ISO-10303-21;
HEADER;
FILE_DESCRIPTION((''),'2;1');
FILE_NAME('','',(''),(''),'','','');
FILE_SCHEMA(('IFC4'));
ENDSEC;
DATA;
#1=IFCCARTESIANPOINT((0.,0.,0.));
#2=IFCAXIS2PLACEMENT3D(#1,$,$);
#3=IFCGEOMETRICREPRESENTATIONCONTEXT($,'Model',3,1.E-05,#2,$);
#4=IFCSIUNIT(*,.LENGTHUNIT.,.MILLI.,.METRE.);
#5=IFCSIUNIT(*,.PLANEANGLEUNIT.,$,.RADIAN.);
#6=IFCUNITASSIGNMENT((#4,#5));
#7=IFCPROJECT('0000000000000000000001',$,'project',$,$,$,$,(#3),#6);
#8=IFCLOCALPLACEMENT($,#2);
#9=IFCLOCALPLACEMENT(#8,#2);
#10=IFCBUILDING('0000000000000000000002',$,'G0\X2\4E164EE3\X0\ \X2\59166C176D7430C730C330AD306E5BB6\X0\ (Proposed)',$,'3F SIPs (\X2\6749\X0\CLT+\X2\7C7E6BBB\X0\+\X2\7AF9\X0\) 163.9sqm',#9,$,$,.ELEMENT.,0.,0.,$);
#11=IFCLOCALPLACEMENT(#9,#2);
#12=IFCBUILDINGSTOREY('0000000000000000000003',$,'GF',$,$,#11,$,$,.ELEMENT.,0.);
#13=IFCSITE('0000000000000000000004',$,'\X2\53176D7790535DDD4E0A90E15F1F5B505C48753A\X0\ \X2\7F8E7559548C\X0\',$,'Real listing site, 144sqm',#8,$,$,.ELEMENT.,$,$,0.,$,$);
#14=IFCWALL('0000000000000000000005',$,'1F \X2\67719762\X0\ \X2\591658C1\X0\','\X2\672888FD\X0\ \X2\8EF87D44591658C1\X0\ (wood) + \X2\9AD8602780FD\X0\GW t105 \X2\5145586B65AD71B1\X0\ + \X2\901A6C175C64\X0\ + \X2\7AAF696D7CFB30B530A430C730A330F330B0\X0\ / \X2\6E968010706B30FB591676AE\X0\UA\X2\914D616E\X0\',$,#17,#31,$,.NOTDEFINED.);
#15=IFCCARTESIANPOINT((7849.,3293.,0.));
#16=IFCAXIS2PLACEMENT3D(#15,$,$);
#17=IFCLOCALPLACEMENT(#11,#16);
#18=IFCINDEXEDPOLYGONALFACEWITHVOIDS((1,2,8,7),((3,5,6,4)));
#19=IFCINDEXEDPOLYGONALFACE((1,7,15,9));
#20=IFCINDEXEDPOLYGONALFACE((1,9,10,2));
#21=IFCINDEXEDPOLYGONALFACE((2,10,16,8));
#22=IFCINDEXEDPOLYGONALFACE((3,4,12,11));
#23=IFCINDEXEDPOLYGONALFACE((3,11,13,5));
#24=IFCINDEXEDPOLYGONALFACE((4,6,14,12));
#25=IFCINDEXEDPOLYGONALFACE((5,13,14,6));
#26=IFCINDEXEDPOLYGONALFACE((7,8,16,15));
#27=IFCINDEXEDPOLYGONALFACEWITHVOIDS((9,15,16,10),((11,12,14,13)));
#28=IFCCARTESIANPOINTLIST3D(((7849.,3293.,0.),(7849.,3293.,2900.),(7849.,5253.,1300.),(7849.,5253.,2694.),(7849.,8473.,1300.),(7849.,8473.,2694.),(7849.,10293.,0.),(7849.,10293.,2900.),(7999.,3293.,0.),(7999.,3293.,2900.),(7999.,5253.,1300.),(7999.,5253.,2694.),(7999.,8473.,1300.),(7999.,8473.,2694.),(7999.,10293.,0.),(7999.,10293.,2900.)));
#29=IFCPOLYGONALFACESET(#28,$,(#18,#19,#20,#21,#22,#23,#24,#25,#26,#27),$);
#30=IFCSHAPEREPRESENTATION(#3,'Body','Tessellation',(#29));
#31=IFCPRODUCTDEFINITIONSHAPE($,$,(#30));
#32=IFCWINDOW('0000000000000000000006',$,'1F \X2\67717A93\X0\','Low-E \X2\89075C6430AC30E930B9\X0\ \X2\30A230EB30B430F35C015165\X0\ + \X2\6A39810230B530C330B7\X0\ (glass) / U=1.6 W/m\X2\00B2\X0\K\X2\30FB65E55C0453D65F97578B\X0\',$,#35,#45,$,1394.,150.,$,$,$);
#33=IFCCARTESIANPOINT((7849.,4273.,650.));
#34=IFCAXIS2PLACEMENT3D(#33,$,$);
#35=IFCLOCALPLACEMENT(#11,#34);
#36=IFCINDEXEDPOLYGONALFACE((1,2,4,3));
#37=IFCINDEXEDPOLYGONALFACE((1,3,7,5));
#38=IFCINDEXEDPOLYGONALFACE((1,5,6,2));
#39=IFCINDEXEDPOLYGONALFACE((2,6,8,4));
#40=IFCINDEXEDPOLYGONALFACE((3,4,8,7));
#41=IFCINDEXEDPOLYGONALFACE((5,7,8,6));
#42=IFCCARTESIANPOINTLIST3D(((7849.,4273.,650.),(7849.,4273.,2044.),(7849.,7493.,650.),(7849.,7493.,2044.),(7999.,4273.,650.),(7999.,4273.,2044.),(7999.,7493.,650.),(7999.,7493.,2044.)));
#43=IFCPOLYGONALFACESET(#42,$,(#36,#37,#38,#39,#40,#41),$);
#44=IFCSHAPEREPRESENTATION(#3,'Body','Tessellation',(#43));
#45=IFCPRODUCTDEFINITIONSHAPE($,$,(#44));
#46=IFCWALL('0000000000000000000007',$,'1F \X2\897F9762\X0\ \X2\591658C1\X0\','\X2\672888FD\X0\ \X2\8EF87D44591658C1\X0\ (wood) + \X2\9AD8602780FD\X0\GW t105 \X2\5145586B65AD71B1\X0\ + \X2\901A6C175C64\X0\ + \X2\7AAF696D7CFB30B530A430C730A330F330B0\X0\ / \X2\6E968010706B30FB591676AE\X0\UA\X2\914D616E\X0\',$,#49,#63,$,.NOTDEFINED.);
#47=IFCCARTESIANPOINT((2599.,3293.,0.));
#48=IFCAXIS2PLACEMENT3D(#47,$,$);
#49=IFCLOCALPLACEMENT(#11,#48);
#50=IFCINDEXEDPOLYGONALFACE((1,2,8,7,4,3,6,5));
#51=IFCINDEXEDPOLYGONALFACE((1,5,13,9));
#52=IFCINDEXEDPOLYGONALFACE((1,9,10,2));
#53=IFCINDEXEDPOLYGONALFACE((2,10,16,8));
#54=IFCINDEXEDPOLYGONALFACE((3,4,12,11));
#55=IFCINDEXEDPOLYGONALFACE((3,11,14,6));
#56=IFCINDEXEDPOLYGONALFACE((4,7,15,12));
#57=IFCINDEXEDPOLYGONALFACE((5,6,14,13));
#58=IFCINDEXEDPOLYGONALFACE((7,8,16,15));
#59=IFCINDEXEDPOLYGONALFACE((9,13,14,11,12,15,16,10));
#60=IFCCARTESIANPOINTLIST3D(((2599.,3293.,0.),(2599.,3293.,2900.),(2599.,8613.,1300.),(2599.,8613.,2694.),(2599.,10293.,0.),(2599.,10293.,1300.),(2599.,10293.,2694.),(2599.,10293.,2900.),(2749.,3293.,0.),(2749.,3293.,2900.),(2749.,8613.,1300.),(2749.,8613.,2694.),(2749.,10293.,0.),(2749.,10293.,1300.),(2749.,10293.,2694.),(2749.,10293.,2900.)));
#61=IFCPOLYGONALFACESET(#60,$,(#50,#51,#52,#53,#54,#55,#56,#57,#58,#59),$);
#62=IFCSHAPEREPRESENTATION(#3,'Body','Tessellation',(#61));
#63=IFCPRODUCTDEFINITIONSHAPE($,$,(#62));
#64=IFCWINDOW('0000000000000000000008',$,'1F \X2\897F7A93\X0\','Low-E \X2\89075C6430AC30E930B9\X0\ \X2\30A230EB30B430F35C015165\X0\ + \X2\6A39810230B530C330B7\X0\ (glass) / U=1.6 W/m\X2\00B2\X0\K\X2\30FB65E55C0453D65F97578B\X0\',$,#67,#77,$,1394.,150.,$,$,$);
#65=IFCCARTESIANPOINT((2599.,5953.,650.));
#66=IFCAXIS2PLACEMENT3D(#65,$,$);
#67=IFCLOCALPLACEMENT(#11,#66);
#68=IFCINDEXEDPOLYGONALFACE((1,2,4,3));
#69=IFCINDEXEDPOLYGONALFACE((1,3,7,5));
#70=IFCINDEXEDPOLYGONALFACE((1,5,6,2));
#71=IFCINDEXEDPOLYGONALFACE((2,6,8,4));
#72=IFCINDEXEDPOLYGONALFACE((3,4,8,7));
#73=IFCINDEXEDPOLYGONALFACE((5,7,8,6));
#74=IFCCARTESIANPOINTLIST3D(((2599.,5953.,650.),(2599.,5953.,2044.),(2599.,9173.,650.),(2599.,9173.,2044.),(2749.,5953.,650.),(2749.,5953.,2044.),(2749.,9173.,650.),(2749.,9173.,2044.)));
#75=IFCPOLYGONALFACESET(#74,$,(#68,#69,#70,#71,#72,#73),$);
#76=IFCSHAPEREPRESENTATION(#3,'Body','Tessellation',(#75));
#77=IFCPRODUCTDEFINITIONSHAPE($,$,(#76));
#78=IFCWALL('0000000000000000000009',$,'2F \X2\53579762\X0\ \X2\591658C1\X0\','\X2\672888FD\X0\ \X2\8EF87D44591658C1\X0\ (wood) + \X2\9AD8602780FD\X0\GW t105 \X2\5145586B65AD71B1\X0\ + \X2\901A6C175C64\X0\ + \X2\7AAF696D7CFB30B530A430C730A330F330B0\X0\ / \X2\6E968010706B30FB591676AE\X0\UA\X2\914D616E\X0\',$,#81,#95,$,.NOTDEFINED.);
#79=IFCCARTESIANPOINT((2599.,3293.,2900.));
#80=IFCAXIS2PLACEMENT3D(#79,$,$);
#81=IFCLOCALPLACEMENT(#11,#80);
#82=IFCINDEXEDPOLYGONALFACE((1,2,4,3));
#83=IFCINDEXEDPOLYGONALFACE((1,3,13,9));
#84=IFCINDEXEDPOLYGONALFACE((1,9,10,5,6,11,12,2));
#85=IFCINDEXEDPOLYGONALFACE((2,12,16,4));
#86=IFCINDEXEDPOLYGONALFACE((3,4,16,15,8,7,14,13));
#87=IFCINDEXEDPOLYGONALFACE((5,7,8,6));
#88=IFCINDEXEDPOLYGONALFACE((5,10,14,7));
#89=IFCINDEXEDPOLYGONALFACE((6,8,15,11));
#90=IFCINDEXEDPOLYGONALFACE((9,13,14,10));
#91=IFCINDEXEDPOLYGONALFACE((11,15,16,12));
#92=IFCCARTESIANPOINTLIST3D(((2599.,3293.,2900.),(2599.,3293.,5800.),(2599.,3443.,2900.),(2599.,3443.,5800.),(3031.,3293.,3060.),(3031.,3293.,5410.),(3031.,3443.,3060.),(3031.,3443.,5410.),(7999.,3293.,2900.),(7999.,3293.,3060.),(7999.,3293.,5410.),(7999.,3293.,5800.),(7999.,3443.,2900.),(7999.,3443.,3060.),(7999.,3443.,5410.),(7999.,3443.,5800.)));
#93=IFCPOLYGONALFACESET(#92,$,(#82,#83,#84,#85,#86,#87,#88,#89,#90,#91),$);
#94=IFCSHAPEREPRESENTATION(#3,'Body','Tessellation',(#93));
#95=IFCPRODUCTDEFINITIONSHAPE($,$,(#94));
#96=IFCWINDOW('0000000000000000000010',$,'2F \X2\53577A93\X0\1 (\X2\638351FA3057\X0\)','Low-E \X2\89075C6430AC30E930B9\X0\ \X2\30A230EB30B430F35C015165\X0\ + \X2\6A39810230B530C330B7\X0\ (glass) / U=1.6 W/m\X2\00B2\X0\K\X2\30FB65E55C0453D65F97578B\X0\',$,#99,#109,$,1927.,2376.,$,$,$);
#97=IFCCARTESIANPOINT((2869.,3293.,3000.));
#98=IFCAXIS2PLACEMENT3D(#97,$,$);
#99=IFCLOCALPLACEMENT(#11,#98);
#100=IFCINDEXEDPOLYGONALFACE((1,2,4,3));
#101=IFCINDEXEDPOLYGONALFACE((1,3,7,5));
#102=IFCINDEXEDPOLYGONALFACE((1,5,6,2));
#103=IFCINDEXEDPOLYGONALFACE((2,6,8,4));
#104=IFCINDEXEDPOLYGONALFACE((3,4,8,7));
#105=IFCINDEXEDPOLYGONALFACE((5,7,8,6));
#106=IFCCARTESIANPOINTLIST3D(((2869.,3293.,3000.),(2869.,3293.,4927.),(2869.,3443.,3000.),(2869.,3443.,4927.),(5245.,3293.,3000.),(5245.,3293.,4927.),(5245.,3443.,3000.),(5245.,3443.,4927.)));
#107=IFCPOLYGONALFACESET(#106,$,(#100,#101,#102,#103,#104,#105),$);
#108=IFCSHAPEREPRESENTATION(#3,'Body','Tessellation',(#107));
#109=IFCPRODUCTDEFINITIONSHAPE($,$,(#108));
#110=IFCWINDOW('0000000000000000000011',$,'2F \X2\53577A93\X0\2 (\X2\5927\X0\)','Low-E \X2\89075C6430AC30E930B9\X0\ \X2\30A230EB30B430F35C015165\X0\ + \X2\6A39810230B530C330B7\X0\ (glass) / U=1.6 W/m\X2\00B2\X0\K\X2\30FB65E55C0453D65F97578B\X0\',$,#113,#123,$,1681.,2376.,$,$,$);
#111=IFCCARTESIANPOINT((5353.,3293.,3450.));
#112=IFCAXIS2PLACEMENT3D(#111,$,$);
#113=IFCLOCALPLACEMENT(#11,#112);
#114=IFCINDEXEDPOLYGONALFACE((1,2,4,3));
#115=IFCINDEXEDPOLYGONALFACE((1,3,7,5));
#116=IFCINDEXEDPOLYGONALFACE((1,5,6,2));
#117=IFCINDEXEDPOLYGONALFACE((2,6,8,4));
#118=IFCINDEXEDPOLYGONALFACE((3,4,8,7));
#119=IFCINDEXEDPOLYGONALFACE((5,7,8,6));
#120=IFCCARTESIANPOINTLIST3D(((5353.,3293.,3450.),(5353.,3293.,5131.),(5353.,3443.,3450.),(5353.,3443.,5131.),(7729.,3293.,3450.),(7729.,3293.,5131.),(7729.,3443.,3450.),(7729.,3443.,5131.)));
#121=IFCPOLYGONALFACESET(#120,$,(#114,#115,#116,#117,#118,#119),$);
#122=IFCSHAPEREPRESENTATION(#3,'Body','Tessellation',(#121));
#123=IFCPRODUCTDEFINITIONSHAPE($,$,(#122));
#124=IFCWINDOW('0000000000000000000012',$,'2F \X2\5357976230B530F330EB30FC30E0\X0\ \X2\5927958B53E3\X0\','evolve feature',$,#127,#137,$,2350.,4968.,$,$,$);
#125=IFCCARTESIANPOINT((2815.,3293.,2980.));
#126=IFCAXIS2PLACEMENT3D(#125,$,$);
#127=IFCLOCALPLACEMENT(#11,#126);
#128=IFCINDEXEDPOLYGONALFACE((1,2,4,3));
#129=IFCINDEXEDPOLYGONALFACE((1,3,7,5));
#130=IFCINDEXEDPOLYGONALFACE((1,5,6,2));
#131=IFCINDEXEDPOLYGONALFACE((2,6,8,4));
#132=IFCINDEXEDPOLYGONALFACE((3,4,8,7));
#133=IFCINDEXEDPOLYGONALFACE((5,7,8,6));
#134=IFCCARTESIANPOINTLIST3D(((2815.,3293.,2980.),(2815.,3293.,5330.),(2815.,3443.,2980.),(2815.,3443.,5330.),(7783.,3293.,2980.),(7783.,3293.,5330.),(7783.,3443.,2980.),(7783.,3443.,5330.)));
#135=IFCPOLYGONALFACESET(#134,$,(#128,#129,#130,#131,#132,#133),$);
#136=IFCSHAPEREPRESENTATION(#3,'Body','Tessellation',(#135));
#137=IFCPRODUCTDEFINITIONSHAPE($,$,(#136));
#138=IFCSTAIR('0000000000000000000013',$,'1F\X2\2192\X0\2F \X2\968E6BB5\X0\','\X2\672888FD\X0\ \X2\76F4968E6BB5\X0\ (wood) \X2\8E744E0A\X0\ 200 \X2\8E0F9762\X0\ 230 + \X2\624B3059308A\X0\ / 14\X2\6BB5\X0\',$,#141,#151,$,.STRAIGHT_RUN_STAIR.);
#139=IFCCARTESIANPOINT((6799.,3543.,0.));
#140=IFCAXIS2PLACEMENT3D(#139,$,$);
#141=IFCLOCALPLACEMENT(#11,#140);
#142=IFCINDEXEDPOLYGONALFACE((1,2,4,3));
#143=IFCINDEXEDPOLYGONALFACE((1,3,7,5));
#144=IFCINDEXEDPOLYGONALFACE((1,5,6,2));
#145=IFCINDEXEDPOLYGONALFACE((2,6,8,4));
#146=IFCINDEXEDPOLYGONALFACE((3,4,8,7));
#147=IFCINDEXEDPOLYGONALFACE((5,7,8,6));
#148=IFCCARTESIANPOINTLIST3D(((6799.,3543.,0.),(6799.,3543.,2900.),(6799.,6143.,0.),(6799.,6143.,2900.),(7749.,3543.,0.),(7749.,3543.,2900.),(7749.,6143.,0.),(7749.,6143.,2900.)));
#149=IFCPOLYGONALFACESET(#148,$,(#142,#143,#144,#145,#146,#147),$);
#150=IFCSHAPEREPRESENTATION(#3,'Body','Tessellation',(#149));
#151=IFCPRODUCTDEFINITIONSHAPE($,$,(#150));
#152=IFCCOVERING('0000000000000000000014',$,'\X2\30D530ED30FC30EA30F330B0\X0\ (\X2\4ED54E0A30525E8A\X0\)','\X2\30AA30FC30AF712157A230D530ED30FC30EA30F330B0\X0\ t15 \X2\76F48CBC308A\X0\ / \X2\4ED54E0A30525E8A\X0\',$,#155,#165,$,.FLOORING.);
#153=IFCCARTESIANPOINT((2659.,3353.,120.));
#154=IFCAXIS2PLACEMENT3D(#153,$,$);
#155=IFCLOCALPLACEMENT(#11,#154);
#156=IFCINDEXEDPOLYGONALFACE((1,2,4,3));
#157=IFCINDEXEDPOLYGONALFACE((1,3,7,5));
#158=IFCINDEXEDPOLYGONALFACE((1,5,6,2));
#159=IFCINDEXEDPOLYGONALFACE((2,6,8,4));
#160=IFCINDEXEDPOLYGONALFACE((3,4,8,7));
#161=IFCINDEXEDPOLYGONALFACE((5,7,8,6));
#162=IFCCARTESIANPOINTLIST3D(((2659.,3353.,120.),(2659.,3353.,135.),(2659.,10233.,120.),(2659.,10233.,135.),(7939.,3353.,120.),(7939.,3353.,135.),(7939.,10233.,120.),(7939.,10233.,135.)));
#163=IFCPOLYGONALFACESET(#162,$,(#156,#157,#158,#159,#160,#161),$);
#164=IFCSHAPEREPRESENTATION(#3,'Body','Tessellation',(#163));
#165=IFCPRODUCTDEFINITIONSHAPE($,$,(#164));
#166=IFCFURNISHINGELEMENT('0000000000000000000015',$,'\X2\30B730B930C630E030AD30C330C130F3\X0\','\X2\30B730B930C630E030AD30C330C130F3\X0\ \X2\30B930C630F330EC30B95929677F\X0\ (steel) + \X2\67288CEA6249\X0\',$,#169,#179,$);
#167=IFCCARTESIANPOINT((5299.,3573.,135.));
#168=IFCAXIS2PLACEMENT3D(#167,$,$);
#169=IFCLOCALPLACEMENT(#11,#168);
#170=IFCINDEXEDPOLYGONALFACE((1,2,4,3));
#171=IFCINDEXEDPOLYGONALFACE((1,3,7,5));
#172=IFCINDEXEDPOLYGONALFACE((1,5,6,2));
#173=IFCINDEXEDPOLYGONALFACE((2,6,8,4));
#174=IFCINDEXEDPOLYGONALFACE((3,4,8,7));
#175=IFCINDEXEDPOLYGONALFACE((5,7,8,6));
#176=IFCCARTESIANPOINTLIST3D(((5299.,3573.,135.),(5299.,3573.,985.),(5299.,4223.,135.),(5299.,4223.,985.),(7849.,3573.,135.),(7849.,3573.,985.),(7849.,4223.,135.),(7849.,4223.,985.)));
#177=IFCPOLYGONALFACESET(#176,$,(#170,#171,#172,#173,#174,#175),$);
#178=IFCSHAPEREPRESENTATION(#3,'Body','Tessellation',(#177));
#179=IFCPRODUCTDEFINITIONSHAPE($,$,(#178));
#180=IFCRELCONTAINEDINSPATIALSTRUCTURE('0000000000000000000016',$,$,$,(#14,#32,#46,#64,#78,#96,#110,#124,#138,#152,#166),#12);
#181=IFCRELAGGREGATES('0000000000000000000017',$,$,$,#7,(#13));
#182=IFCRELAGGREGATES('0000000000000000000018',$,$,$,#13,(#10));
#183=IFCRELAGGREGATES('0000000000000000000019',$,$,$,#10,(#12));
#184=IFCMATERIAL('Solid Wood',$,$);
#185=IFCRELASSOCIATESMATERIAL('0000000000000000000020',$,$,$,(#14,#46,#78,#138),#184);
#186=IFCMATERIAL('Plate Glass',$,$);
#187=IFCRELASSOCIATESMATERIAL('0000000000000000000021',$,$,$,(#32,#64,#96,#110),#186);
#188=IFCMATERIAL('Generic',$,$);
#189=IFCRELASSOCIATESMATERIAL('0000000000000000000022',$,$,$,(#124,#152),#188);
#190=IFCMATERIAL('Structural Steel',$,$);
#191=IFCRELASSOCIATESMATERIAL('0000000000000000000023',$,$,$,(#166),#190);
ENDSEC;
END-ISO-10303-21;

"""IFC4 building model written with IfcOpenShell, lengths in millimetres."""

from ifc_helpers import new_model, si_unit, frame, frame_2d, origin, place, context, project, spatial, rectangle, extrude, material, element, fill, save


model = new_model("IFC4")

# Units and contexts
model_context = context("Model", 3, precision=1e-05, world=origin())
ifc_project = project(units=[si_unit("LENGTHUNIT", "METRE", prefix="MILLI"), si_unit("PLANEANGLEUNIT", "RADIAN")], contexts=[model_context])

# Site, building, storey
site_placement = place(None, origin())
site = spatial("IfcSite", under=ifc_project, at=site_placement, Name="北海道川上郡弟子屈町 美留和", ObjectType="Real listing site, 144sqm", CompositionType="ELEMENT", RefElevation=0.0)
building_placement = place(site_placement, origin())
building = spatial("IfcBuilding", under=site, at=building_placement, Name="G0世代 外気浴デッキの家 (Proposed)", ObjectType="3F SIPs (杉CLT+籾殻+竹) 163.9sqm", CompositionType="ELEMENT", ElevationOfRefHeight=0.0, ElevationOfTerrain=0.0)
storey_placement = place(building_placement, origin())
storey = spatial("IfcBuildingStorey", under=building, at=storey_placement, Name="GF", CompositionType="ELEMENT", Elevation=0.0)

# Shared definitions
ifc_material_1 = material(Name="Solid Wood")
ifc_material_2 = material(Name="Generic")

# Shared definitions
ifc_material_3 = material(Name="Plate Glass")

# Walls, openings, windows
wall_1_placement = place(storey_placement, frame((7849.0, 3293.0, 0.0)))
wall_1 = element("IfcWall", 1, at=wall_1_placement, inside=storey, material=ifc_material_1, Name="1F 東面 外壁", Description="木製 軸組外壁 (wood) + 高性能GW t105 充填断熱 + 通気層 + 窯業系サイディング / 準耐火・外皮UA配慮", PredefinedType="NOTDEFINED", context=model_context, shape_type="SweptSolid", body=[
    extrude(rectangle(XDim=150.0, YDim=7000.0, at=frame_2d((75.0, 3500.0))), frame((7849.0, 3293.0, 0.0)), (0.0, 0.0, 1.0), 2900.0),
])
opening_1_placement = place(storey_placement, frame((7849.0, 4273.0, 650.0)))
opening_1 = element("IfcOpeningElement", 2, at=opening_1_placement, cuts=wall_1, PredefinedType="NOTDEFINED", context=model_context, shape_type="SweptSolid", body=[
    extrude(rectangle(XDim=150.0, YDim=3220.0, at=frame_2d((75.0, 1610.0))), frame((7849.0, 4273.0, 650.0)), (0.0, 0.0, 1.0), 1394.0),
])
window_1_placement = place(storey_placement, frame((7849.0, 4273.0, 650.0)))
window_1 = element("IfcWindow", 3, at=window_1_placement, inside=storey, material=ifc_material_3, Name="1F 東窓", Description="Low-E 複層ガラス アルゴン封入 + 樹脂サッシ (glass) / U=1.6 W/m²K・日射取得型", OverallHeight=1394.0, OverallWidth=150.0, context=model_context, shape_type="SweptSolid", body=[
    extrude(rectangle(XDim=150.0, YDim=3220.0, at=frame_2d((75.0, 1610.0))), frame((7849.0, 4273.0, 650.0)), (0.0, 0.0, 1.0), 1394.0),
])
fill(opening_1, window_1)
wall_2_placement = place(storey_placement, frame((2599.0, 3293.0, 0.0)))
wall_2 = element("IfcWall", 4, at=wall_2_placement, inside=storey, material=ifc_material_1, Name="1F 西面 外壁", Description="木製 軸組外壁 (wood) + 高性能GW t105 充填断熱 + 通気層 + 窯業系サイディング / 準耐火・外皮UA配慮", PredefinedType="NOTDEFINED", context=model_context, shape_type="SweptSolid", body=[
    extrude(rectangle(XDim=150.0, YDim=7000.0, at=frame_2d((75.0, 3500.0))), frame((2599.0, 3293.0, 0.0)), (0.0, 0.0, 1.0), 2900.0),
])
opening_2_placement = place(storey_placement, frame((2599.0, 5953.0, 650.0)))
opening_2 = element("IfcOpeningElement", 5, at=opening_2_placement, cuts=wall_2, PredefinedType="NOTDEFINED", context=model_context, shape_type="SweptSolid", body=[
    extrude(rectangle(XDim=150.0, YDim=3220.0, at=frame_2d((75.0, 1610.0))), frame((2599.0, 5953.0, 650.0)), (0.0, 0.0, 1.0), 1394.0),
])
window_2_placement = place(storey_placement, frame((2599.0, 5953.0, 650.0)))
window_2 = element("IfcWindow", 6, at=window_2_placement, inside=storey, material=ifc_material_3, Name="1F 西窓", Description="Low-E 複層ガラス アルゴン封入 + 樹脂サッシ (glass) / U=1.6 W/m²K・日射取得型", OverallHeight=1394.0, OverallWidth=150.0, context=model_context, shape_type="SweptSolid", body=[
    extrude(rectangle(XDim=150.0, YDim=3220.0, at=frame_2d((75.0, 1610.0))), frame((2599.0, 5953.0, 650.0)), (0.0, 0.0, 1.0), 1394.0),
])
fill(opening_2, window_2)

# Wall, openings, windows
wall_3_placement = place(storey_placement, frame((2599.0, 3293.0, 2900.0)))
wall_3 = element("IfcWall", 7, at=wall_3_placement, inside=storey, material=ifc_material_1, Name="2F 南面 外壁", Description="木製 軸組外壁 (wood) + 高性能GW t105 充填断熱 + 通気層 + 窯業系サイディング / 準耐火・外皮UA配慮", PredefinedType="NOTDEFINED", context=model_context, shape_type="SweptSolid", body=[
    extrude(rectangle(XDim=5400.0, YDim=150.0, at=frame_2d((2700.0, 75.0))), frame((2599.0, 3293.0, 2900.0)), (0.0, 0.0, 1.0), 2900.0),
])
opening_3_placement = place(storey_placement, frame((2869.0, 3293.0, 3000.0)))
opening_3 = element("IfcOpeningElement", 8, at=opening_3_placement, cuts=wall_3, PredefinedType="NOTDEFINED", context=model_context, shape_type="SweptSolid", body=[
    extrude(rectangle(XDim=2376.0, YDim=150.0, at=frame_2d((1188.0, 75.0))), frame((2869.0, 3293.0, 3000.0)), (0.0, 0.0, 1.0), 1927.0),
])
opening_4_placement = place(storey_placement, frame((5353.0, 3293.0, 3450.0)))
opening_4 = element("IfcOpeningElement", 9, at=opening_4_placement, cuts=wall_3, PredefinedType="NOTDEFINED", context=model_context, shape_type="SweptSolid", body=[
    extrude(rectangle(XDim=2376.0, YDim=150.0, at=frame_2d((1188.0, 75.0))), frame((5353.0, 3293.0, 3450.0)), (0.0, 0.0, 1.0), 1681.0),
])
opening_5_placement = place(storey_placement, frame((2815.0, 3293.0, 2980.0)))
opening_5 = element("IfcOpeningElement", 10, at=opening_5_placement, cuts=wall_3, PredefinedType="NOTDEFINED", context=model_context, shape_type="SweptSolid", body=[
    extrude(rectangle(XDim=4968.0, YDim=150.0, at=frame_2d((2484.0, 75.0))), frame((2815.0, 3293.0, 2980.0)), (0.0, 0.0, 1.0), 2350.0),
])
window_3_placement = place(storey_placement, frame((2869.0, 3293.0, 3000.0)))
window_3 = element("IfcWindow", 11, at=window_3_placement, inside=storey, material=ifc_material_3, Name="2F 南窓1 (掃出し)", Description="Low-E 複層ガラス アルゴン封入 + 樹脂サッシ (glass) / U=1.6 W/m²K・日射取得型", OverallHeight=1927.0, OverallWidth=2376.0, context=model_context, shape_type="SweptSolid", body=[
    extrude(rectangle(XDim=2376.0, YDim=150.0, at=frame_2d((1188.0, 75.0))), frame((2869.0, 3293.0, 3000.0)), (0.0, 0.0, 1.0), 1927.0),
])
fill(opening_3, window_3)
window_4_placement = place(storey_placement, frame((5353.0, 3293.0, 3450.0)))
window_4 = element("IfcWindow", 12, at=window_4_placement, inside=storey, material=ifc_material_3, Name="2F 南窓2 (大)", Description="Low-E 複層ガラス アルゴン封入 + 樹脂サッシ (glass) / U=1.6 W/m²K・日射取得型", OverallHeight=1681.0, OverallWidth=2376.0, context=model_context, shape_type="SweptSolid", body=[
    extrude(rectangle(XDim=2376.0, YDim=150.0, at=frame_2d((1188.0, 75.0))), frame((5353.0, 3293.0, 3450.0)), (0.0, 0.0, 1.0), 1681.0),
])
fill(opening_4, window_4)
window_5_placement = place(storey_placement, frame((2815.0, 3293.0, 2980.0)))
window_5 = element("IfcWindow", 13, at=window_5_placement, inside=storey, material=ifc_material_2, Name="2F 南面サンルーム 大開口", Description="evolve feature", OverallHeight=2350.0, OverallWidth=4968.0, context=model_context, shape_type="SweptSolid", body=[
    extrude(rectangle(XDim=4968.0, YDim=150.0, at=frame_2d((2484.0, 75.0))), frame((2815.0, 3293.0, 2980.0)), (0.0, 0.0, 1.0), 2350.0),
])
fill(opening_5, window_5)

# Stair
stair_placement = place(storey_placement, frame((6799.0, 3543.0, 0.0)))
element("IfcStair", 14, at=stair_placement, inside=storey, material=ifc_material_1, Name="1F→2F 階段", Description="木製 直階段 (wood) 蹴上 200 踏面 230 + 手すり / 14段", PredefinedType="STRAIGHT_RUN_STAIR", context=model_context, shape_type="SweptSolid", body=[
    extrude(rectangle(XDim=950.0, YDim=2600.0, at=frame_2d((475.0, 1300.0))), frame((6799.0, 3543.0, 0.0)), (0.0, 0.0, 1.0), 2900.0),
])

# Covering
covering_placement = place(storey_placement, frame((2659.0, 3353.0, 120.0)))
element("IfcCovering", 15, at=covering_placement, inside=storey, material=ifc_material_2, Name="フローリング (仕上げ床)", Description="オーク無垢フローリング t15 直貼り / 仕上げ床", PredefinedType="FLOORING", context=model_context, shape_type="SweptSolid", body=[
    extrude(rectangle(XDim=5280.0, YDim=6880.0, at=frame_2d((2640.0, 3440.0))), frame((2659.0, 3353.0, 120.0)), (0.0, 0.0, 1.0), 15.0),
])

# Furnishing element
ifc_material_4 = material(Name="Structural Steel")
furnishing_placement = place(storey_placement, frame((5299.0, 3573.0, 135.0)))
element("IfcFurnishingElement", 16, at=furnishing_placement, inside=storey, material=ifc_material_4, Name="システムキッチン", Description="システムキッチン ステンレス天板 (steel) + 木質扉", context=model_context, shape_type="SweptSolid", body=[
    extrude(rectangle(XDim=2550.0, YDim=650.0, at=frame_2d((1275.0, 325.0))), frame((5299.0, 3573.0, 135.0)), (0.0, 0.0, 1.0), 850.0),
])

save(model, "model.ifc")
